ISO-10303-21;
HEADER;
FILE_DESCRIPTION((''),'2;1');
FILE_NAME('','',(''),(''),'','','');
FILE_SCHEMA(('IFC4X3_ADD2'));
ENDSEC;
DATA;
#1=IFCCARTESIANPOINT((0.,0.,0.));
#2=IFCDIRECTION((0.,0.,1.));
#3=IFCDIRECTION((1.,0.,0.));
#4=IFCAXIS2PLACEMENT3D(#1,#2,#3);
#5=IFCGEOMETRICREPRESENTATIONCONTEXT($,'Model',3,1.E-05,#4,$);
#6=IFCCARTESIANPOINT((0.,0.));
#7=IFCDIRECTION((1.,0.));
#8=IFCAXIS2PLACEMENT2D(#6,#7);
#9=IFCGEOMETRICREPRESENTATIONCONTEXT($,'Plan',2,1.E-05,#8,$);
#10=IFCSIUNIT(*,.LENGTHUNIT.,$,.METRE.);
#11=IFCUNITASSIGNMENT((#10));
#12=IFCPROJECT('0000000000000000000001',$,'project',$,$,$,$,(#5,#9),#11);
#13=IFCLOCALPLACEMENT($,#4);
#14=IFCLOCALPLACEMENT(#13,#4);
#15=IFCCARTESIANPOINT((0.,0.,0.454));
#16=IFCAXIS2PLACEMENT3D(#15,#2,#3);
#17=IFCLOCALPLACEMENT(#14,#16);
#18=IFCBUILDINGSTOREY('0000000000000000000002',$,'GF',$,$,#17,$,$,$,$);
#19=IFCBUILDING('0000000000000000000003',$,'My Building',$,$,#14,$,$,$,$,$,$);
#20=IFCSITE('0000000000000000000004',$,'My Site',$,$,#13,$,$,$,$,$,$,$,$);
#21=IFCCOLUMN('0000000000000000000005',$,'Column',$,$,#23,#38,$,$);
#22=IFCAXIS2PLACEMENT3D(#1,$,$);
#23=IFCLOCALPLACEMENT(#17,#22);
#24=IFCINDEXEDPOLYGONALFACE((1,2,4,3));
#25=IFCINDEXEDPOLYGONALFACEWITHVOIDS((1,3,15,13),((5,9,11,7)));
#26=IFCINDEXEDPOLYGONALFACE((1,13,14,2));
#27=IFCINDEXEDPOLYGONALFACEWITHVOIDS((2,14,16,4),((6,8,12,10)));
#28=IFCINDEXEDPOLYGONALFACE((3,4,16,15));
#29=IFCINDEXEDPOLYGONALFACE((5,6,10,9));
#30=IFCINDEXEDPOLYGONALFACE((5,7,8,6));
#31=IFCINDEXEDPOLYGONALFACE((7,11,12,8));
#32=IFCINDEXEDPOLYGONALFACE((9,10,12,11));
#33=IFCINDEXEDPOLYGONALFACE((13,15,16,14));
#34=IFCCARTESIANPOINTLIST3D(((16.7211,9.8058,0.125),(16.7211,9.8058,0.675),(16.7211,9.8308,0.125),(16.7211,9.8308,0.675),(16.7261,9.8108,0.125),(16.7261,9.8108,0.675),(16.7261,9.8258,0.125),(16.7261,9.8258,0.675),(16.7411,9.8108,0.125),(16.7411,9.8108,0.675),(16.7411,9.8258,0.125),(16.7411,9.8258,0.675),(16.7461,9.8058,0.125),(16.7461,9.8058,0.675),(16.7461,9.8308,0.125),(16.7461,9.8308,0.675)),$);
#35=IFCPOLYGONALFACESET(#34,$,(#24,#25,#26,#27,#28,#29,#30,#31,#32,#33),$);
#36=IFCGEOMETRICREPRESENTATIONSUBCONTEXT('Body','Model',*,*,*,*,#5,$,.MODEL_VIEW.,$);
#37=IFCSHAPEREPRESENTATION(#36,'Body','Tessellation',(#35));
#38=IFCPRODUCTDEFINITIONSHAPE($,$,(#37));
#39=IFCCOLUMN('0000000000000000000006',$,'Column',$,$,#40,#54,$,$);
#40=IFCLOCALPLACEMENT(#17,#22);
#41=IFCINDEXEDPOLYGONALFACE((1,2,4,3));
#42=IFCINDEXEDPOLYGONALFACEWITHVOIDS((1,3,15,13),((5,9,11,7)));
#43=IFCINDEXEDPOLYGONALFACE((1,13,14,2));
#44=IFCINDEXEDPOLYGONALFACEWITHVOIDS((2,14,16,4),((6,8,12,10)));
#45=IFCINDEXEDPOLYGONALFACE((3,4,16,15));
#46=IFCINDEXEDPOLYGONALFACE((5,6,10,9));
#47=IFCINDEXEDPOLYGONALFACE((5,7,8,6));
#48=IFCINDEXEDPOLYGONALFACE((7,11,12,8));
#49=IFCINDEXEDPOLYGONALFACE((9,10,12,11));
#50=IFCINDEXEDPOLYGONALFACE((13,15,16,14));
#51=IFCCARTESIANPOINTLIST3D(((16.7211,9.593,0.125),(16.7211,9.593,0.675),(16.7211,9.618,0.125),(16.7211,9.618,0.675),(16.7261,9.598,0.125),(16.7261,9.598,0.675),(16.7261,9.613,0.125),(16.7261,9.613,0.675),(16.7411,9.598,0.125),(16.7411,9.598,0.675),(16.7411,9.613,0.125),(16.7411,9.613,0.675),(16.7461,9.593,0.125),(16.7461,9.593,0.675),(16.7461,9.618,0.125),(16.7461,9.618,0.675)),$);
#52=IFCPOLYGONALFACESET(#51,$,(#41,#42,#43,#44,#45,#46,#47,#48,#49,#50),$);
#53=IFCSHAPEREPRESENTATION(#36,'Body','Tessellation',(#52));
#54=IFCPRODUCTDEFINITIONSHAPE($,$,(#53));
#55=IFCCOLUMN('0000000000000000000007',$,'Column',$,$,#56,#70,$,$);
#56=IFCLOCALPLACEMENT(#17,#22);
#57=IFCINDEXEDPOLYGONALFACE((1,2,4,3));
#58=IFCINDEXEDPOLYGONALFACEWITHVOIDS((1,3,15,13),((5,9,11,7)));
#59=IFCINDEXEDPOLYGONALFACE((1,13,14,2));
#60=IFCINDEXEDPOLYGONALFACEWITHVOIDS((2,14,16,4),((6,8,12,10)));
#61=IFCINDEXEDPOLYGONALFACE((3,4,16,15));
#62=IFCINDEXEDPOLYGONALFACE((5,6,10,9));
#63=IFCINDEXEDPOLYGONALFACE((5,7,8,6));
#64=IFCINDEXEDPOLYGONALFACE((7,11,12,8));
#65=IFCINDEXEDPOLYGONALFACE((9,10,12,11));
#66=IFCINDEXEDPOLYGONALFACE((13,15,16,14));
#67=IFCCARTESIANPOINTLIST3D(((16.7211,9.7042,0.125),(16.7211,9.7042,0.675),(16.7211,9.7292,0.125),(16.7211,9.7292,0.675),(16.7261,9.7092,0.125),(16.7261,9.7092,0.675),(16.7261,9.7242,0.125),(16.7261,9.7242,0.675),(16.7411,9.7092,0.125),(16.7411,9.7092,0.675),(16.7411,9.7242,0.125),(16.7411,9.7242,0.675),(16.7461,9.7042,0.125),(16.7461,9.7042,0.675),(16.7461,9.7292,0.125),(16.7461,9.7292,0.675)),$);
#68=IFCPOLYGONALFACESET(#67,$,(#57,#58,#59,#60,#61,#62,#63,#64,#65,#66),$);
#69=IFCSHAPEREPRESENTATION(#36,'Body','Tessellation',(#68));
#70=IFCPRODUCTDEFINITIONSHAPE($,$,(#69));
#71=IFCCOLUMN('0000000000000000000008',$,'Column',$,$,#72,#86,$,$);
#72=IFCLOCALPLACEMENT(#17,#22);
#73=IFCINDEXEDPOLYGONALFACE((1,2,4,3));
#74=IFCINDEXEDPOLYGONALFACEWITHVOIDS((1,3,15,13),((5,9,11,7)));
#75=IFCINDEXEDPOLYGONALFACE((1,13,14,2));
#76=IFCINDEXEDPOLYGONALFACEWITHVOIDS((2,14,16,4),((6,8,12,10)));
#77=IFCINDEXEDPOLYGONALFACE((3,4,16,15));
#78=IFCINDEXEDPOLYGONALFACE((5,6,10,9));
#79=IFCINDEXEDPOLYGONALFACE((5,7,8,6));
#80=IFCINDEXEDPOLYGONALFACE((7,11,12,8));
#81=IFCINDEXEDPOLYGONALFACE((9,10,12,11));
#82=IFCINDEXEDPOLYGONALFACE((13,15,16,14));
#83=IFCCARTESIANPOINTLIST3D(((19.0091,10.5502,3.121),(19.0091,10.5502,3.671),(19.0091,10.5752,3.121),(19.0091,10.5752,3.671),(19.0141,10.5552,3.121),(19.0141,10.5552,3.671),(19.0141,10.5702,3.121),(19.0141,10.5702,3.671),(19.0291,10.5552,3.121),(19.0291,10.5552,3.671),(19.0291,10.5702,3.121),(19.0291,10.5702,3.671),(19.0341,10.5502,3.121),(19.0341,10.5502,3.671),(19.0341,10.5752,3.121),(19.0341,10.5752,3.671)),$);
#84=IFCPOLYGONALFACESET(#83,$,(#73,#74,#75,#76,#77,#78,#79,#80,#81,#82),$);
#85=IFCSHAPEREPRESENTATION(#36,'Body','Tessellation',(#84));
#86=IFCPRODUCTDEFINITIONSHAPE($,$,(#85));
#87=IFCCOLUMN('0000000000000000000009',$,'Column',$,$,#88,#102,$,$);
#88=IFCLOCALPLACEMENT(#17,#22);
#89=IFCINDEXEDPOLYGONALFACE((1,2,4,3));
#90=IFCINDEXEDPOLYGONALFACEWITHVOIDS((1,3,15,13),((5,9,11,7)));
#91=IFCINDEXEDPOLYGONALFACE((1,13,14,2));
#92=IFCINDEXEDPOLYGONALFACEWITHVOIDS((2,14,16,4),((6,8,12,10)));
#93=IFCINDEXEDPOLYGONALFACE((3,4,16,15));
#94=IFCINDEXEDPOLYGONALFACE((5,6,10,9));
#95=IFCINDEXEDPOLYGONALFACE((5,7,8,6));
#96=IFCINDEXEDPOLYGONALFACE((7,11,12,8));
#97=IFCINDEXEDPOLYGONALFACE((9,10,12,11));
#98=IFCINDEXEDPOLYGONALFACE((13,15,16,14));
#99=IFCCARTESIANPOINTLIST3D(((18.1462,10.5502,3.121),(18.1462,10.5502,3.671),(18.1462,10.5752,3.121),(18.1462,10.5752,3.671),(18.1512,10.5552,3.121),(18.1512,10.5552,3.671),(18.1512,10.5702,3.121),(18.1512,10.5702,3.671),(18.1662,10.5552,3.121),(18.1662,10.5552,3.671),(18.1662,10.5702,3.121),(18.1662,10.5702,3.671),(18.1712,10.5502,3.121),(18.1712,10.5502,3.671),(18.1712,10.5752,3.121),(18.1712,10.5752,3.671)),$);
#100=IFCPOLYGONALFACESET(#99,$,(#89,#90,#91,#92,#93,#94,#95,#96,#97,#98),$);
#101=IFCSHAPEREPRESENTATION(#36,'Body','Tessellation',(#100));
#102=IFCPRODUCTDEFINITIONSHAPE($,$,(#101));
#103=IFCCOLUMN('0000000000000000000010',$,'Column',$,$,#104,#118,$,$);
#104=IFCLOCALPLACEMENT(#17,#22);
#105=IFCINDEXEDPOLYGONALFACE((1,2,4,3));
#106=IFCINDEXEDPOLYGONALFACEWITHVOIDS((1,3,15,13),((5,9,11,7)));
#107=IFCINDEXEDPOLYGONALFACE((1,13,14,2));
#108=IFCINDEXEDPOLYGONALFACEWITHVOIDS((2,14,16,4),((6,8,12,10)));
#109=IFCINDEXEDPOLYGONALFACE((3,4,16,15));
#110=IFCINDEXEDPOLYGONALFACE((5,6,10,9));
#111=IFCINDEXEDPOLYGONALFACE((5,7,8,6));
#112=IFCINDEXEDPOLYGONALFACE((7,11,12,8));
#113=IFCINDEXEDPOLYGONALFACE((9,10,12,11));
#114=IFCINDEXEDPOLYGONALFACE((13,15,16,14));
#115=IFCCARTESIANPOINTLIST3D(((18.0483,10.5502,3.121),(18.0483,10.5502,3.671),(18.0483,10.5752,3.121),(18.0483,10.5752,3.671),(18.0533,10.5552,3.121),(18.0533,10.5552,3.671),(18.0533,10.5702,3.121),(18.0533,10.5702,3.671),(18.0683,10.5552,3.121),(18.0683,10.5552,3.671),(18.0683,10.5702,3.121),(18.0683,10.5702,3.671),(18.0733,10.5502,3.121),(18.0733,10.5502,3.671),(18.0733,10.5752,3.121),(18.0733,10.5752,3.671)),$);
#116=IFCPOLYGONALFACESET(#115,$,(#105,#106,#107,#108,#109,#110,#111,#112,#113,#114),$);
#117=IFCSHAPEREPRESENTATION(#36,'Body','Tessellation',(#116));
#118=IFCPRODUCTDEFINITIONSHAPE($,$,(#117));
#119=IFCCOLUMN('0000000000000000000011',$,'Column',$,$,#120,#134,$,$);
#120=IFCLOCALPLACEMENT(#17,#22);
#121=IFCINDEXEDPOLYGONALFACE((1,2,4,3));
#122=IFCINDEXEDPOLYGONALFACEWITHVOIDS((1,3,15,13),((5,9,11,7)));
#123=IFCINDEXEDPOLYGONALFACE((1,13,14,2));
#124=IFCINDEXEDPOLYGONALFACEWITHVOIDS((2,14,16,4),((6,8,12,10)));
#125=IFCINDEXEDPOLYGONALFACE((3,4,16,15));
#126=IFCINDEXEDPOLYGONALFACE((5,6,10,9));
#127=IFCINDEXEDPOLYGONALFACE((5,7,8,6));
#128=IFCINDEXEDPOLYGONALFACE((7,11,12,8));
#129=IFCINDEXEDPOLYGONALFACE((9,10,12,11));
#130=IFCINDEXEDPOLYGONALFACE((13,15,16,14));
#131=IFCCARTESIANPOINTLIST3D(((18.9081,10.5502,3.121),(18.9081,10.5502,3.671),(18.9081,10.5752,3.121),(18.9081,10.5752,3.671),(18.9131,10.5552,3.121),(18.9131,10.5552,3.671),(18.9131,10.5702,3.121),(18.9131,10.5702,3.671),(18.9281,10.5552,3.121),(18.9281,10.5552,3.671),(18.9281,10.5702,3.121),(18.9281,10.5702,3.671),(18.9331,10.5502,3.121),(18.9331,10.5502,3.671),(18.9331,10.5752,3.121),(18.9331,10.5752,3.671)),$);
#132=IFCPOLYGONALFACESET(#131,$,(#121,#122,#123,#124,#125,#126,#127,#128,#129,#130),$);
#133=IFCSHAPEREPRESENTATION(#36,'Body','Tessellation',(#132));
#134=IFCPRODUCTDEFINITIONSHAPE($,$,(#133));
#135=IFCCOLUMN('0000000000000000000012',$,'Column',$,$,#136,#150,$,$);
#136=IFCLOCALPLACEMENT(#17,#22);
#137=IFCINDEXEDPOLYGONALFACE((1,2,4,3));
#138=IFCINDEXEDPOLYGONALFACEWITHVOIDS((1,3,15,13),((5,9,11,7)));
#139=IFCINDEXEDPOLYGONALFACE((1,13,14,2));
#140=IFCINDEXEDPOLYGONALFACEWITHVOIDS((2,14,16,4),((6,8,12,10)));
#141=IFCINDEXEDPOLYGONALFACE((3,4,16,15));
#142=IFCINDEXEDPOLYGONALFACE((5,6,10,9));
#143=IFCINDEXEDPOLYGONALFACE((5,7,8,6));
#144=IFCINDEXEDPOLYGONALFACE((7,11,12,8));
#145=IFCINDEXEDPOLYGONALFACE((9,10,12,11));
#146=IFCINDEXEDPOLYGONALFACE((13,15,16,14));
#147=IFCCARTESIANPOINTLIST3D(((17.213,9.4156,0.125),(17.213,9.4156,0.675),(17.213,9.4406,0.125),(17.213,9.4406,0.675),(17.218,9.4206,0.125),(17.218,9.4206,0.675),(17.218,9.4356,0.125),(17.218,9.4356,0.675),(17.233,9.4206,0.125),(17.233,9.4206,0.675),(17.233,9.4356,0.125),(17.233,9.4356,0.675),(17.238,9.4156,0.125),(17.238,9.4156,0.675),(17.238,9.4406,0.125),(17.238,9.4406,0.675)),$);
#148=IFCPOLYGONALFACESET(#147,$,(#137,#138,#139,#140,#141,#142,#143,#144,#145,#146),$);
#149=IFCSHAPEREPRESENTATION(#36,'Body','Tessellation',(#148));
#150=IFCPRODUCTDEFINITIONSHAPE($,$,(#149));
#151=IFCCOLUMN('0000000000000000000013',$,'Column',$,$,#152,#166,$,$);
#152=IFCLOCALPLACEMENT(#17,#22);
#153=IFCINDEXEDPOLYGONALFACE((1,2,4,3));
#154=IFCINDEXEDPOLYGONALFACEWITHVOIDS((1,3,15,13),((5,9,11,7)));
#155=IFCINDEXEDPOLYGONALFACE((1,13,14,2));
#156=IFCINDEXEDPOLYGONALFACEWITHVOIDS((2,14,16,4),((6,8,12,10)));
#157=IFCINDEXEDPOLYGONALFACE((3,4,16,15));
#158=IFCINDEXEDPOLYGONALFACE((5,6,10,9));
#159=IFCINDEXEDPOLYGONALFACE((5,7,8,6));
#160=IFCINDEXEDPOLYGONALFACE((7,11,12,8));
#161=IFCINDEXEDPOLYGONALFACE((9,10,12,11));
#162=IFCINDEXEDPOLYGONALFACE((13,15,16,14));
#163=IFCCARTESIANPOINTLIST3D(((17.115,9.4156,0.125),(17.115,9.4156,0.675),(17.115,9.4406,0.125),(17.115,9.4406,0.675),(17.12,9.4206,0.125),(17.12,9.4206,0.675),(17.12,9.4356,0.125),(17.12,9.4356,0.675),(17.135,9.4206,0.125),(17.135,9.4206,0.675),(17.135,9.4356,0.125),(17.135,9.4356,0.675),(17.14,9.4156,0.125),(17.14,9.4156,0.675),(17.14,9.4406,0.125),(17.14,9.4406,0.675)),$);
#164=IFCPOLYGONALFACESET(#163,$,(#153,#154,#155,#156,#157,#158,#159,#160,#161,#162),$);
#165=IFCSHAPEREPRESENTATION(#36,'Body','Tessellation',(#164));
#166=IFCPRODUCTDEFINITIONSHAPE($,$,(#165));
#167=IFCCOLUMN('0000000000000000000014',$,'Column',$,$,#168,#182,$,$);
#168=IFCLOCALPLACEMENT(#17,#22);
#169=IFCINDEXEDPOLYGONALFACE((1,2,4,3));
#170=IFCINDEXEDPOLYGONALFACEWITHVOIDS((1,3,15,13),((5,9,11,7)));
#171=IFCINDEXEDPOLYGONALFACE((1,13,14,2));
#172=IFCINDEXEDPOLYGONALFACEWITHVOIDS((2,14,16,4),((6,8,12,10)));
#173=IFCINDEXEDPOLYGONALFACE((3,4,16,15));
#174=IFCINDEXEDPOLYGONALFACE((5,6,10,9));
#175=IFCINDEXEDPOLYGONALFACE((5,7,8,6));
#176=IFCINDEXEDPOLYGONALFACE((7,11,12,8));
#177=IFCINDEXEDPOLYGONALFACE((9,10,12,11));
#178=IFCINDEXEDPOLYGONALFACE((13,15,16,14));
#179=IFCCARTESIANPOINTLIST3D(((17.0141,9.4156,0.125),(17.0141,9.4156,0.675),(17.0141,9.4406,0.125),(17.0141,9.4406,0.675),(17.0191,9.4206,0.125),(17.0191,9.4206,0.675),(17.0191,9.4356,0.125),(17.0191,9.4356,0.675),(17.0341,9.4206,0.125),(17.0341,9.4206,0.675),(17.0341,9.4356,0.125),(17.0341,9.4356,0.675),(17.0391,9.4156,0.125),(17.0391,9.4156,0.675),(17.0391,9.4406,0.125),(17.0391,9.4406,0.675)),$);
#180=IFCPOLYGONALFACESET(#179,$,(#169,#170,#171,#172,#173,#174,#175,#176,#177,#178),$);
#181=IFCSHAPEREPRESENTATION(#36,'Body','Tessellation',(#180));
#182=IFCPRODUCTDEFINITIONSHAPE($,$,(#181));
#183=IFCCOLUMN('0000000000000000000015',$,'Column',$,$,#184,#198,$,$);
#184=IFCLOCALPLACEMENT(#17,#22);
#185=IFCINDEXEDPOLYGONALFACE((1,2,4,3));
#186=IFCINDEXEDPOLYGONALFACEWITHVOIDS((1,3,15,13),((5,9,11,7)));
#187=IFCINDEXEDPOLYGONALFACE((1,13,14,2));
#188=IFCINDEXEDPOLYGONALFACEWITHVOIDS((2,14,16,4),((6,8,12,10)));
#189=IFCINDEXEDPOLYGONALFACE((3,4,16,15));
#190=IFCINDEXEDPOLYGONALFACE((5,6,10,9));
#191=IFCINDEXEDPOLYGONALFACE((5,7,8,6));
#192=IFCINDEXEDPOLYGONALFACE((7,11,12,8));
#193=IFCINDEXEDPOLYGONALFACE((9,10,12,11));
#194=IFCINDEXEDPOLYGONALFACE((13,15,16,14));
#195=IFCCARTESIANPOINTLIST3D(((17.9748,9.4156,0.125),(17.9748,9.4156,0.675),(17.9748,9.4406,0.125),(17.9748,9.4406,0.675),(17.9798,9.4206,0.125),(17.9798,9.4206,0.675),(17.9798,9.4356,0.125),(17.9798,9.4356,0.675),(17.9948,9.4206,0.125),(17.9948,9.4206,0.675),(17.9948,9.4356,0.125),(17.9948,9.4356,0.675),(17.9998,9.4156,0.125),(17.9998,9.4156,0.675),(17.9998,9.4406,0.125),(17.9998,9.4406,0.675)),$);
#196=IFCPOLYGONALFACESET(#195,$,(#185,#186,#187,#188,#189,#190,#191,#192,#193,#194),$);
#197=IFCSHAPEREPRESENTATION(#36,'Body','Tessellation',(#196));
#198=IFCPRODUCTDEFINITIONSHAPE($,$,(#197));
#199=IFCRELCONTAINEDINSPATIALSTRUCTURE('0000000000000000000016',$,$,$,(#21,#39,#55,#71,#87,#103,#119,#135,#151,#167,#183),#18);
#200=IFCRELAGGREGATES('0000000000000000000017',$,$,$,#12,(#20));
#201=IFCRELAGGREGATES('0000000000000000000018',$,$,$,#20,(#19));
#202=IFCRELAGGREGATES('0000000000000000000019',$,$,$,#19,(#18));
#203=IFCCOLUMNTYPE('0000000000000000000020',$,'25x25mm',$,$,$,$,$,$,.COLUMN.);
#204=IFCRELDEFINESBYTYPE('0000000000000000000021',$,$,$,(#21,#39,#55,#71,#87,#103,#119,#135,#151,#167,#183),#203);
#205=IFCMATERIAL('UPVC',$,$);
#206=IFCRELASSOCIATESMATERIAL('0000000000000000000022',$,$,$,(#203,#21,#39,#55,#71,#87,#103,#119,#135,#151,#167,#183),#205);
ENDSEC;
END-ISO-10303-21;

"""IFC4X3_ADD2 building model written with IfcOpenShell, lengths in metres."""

from ifc_helpers import new_model, si_unit, frame, origin_with_axes, origin_2d_with_axis, place, context, subcontext, project, spatial, hollow_rectangle, extrude, material, material_profile, profile_set, profile_usage, type_object, element, save


model = new_model("IFC4X3_ADD2")

# Units and contexts
model_context = context("Model", 3, precision=1e-05, world=origin_with_axes())
plan_context = context("Plan", 2, precision=1e-05, world=origin_2d_with_axis())
body_context = subcontext(model_context, "Body", "Model", "MODEL_VIEW")
ifc_project = project(units=[si_unit("LENGTHUNIT", "METRE")], contexts=[model_context, plan_context])

# Site, building, storey
site_placement = place(None, origin_with_axes())
site = spatial("IfcSite", under=ifc_project, at=site_placement, Name="My Site")
building_placement = place(site_placement, origin_with_axes())
building = spatial("IfcBuilding", under=site, at=building_placement, Name="My Building")
storey_placement = place(building_placement, frame((0.0, 0.0, 0.454), z_axis=(0.0, 0.0, 1.0), x_axis=(1.0, 0.0, 0.0)))
storey = spatial("IfcBuildingStorey", under=building, at=storey_placement, Name="GF")

# Columns
ifc_material = material(Name="UPVC")
ifc_material_profile_1 = material_profile(ifc_material, hollow_rectangle(XDim=0.025, YDim=0.025, WallThickness=0.005))
ifc_profile_set_1 = profile_set([ifc_material_profile_1])
ifc_profile_usage_1 = profile_usage(ifc_profile_set_1)
column_type_1 = type_object("IfcColumnType", Name="25x25mm", PredefinedType="COLUMN", material=ifc_profile_set_1)
column_1_placement = place(storey_placement, frame((16.7336, 9.8183, 0.125), z_axis=(0.0, 0.0, 1.0), x_axis=(0.0, -1.0, 0.0)))
element("IfcColumn", 1, at=column_1_placement, inside=storey, type_object=column_type_1, material=ifc_profile_usage_1, Name="Column", context=body_context, shape_type="SweptSolid", body=[
    extrude(hollow_rectangle(XDim=0.025, YDim=0.025, WallThickness=0.005), origin_with_axes(), (0.0, 0.0, 1.0), 0.55),
])
ifc_profile_usage_2 = profile_usage(ifc_profile_set_1)
column_2_placement = place(storey_placement, frame((16.7336, 9.6055, 0.125), z_axis=(0.0, 0.0, 1.0), x_axis=(0.0, -1.0, 0.0)))
element("IfcColumn", 2, at=column_2_placement, inside=storey, type_object=column_type_1, material=ifc_profile_usage_2, Name="Column", context=body_context, shape_type="SweptSolid", body=[
    extrude(hollow_rectangle(XDim=0.025, YDim=0.025, WallThickness=0.005), origin_with_axes(), (0.0, 0.0, 1.0), 0.55),
])
ifc_profile_usage_3 = profile_usage(ifc_profile_set_1)
column_3_placement = place(storey_placement, frame((16.7336, 9.7167, 0.125), z_axis=(0.0, 0.0, 1.0), x_axis=(0.0, -1.0, 0.0)))
element("IfcColumn", 3, at=column_3_placement, inside=storey, type_object=column_type_1, material=ifc_profile_usage_3, Name="Column", context=body_context, shape_type="SweptSolid", body=[
    extrude(hollow_rectangle(XDim=0.025, YDim=0.025, WallThickness=0.005), origin_with_axes(), (0.0, 0.0, 1.0), 0.55),
])
ifc_profile_usage_4 = profile_usage(ifc_profile_set_1)
column_4_placement = place(storey_placement, frame((19.0216, 10.5627, 3.121), z_axis=(0.0, 0.0, 1.0), x_axis=(0.0, -1.0, 0.0)))
element("IfcColumn", 4, at=column_4_placement, inside=storey, type_object=column_type_1, material=ifc_profile_usage_4, Name="Column", context=body_context, shape_type="SweptSolid", body=[
    extrude(hollow_rectangle(XDim=0.025, YDim=0.025, WallThickness=0.005), origin_with_axes(), (0.0, 0.0, 1.0), 0.55),
])
ifc_profile_usage_5 = profile_usage(ifc_profile_set_1)
column_5_placement = place(storey_placement, frame((18.1587, 10.5627, 3.121), z_axis=(0.0, 0.0, 1.0), x_axis=(0.0, -1.0, 0.0)))
element("IfcColumn", 5, at=column_5_placement, inside=storey, type_object=column_type_1, material=ifc_profile_usage_5, Name="Column", context=body_context, shape_type="SweptSolid", body=[
    extrude(hollow_rectangle(XDim=0.025, YDim=0.025, WallThickness=0.005), origin_with_axes(), (0.0, 0.0, 1.0), 0.55),
])
ifc_profile_usage_6 = profile_usage(ifc_profile_set_1)
column_6_placement = place(storey_placement, frame((18.0608, 10.5627, 3.121), z_axis=(0.0, 0.0, 1.0), x_axis=(0.0, -1.0, 0.0)))
element("IfcColumn", 6, at=column_6_placement, inside=storey, type_object=column_type_1, material=ifc_profile_usage_6, Name="Column", context=body_context, shape_type="SweptSolid", body=[
    extrude(hollow_rectangle(XDim=0.025, YDim=0.025, WallThickness=0.005), origin_with_axes(), (0.0, 0.0, 1.0), 0.55),
])
ifc_profile_usage_7 = profile_usage(ifc_profile_set_1)
column_7_placement = place(storey_placement, frame((18.9206, 10.5627, 3.121), z_axis=(0.0, 0.0, 1.0), x_axis=(0.0, -1.0, 0.0)))
element("IfcColumn", 7, at=column_7_placement, inside=storey, type_object=column_type_1, material=ifc_profile_usage_7, Name="Column", context=body_context, shape_type="SweptSolid", body=[
    extrude(hollow_rectangle(XDim=0.025, YDim=0.025, WallThickness=0.005), origin_with_axes(), (0.0, 0.0, 1.0), 0.55),
])
ifc_profile_usage_8 = profile_usage(ifc_profile_set_1)
column_8_placement = place(storey_placement, frame((17.2255, 9.4281, 0.125), z_axis=(0.0, 0.0, 1.0), x_axis=(0.0, -1.0, 0.0)))
element("IfcColumn", 8, at=column_8_placement, inside=storey, type_object=column_type_1, material=ifc_profile_usage_8, Name="Column", context=body_context, shape_type="SweptSolid", body=[
    extrude(hollow_rectangle(XDim=0.025, YDim=0.025, WallThickness=0.005), origin_with_axes(), (0.0, 0.0, 1.0), 0.55),
])
ifc_profile_usage_9 = profile_usage(ifc_profile_set_1)
column_9_placement = place(storey_placement, frame((17.1275, 9.4281, 0.125), z_axis=(0.0, 0.0, 1.0), x_axis=(0.0, -1.0, 0.0)))
element("IfcColumn", 9, at=column_9_placement, inside=storey, type_object=column_type_1, material=ifc_profile_usage_9, Name="Column", context=body_context, shape_type="SweptSolid", body=[
    extrude(hollow_rectangle(XDim=0.025, YDim=0.025, WallThickness=0.005), origin_with_axes(), (0.0, 0.0, 1.0), 0.55),
])
ifc_profile_usage_10 = profile_usage(ifc_profile_set_1)
column_10_placement = place(storey_placement, frame((17.0266, 9.4281, 0.125), z_axis=(0.0, 0.0, 1.0), x_axis=(0.0, -1.0, 0.0)))
element("IfcColumn", 10, at=column_10_placement, inside=storey, type_object=column_type_1, material=ifc_profile_usage_10, Name="Column", context=body_context, shape_type="SweptSolid", body=[
    extrude(hollow_rectangle(XDim=0.025, YDim=0.025, WallThickness=0.005), origin_with_axes(), (0.0, 0.0, 1.0), 0.55),
])
ifc_profile_usage_11 = profile_usage(ifc_profile_set_1)
column_11_placement = place(storey_placement, frame((17.9873, 9.4281, 0.125), z_axis=(0.0, 0.0, 1.0), x_axis=(0.0, -1.0, 0.0)))
element("IfcColumn", 11, at=column_11_placement, inside=storey, type_object=column_type_1, material=ifc_profile_usage_11, Name="Column", context=body_context, shape_type="SweptSolid", body=[
    extrude(hollow_rectangle(XDim=0.025, YDim=0.025, WallThickness=0.005), origin_with_axes(), (0.0, 0.0, 1.0), 0.55),
])

save(model, "model.ifc")
